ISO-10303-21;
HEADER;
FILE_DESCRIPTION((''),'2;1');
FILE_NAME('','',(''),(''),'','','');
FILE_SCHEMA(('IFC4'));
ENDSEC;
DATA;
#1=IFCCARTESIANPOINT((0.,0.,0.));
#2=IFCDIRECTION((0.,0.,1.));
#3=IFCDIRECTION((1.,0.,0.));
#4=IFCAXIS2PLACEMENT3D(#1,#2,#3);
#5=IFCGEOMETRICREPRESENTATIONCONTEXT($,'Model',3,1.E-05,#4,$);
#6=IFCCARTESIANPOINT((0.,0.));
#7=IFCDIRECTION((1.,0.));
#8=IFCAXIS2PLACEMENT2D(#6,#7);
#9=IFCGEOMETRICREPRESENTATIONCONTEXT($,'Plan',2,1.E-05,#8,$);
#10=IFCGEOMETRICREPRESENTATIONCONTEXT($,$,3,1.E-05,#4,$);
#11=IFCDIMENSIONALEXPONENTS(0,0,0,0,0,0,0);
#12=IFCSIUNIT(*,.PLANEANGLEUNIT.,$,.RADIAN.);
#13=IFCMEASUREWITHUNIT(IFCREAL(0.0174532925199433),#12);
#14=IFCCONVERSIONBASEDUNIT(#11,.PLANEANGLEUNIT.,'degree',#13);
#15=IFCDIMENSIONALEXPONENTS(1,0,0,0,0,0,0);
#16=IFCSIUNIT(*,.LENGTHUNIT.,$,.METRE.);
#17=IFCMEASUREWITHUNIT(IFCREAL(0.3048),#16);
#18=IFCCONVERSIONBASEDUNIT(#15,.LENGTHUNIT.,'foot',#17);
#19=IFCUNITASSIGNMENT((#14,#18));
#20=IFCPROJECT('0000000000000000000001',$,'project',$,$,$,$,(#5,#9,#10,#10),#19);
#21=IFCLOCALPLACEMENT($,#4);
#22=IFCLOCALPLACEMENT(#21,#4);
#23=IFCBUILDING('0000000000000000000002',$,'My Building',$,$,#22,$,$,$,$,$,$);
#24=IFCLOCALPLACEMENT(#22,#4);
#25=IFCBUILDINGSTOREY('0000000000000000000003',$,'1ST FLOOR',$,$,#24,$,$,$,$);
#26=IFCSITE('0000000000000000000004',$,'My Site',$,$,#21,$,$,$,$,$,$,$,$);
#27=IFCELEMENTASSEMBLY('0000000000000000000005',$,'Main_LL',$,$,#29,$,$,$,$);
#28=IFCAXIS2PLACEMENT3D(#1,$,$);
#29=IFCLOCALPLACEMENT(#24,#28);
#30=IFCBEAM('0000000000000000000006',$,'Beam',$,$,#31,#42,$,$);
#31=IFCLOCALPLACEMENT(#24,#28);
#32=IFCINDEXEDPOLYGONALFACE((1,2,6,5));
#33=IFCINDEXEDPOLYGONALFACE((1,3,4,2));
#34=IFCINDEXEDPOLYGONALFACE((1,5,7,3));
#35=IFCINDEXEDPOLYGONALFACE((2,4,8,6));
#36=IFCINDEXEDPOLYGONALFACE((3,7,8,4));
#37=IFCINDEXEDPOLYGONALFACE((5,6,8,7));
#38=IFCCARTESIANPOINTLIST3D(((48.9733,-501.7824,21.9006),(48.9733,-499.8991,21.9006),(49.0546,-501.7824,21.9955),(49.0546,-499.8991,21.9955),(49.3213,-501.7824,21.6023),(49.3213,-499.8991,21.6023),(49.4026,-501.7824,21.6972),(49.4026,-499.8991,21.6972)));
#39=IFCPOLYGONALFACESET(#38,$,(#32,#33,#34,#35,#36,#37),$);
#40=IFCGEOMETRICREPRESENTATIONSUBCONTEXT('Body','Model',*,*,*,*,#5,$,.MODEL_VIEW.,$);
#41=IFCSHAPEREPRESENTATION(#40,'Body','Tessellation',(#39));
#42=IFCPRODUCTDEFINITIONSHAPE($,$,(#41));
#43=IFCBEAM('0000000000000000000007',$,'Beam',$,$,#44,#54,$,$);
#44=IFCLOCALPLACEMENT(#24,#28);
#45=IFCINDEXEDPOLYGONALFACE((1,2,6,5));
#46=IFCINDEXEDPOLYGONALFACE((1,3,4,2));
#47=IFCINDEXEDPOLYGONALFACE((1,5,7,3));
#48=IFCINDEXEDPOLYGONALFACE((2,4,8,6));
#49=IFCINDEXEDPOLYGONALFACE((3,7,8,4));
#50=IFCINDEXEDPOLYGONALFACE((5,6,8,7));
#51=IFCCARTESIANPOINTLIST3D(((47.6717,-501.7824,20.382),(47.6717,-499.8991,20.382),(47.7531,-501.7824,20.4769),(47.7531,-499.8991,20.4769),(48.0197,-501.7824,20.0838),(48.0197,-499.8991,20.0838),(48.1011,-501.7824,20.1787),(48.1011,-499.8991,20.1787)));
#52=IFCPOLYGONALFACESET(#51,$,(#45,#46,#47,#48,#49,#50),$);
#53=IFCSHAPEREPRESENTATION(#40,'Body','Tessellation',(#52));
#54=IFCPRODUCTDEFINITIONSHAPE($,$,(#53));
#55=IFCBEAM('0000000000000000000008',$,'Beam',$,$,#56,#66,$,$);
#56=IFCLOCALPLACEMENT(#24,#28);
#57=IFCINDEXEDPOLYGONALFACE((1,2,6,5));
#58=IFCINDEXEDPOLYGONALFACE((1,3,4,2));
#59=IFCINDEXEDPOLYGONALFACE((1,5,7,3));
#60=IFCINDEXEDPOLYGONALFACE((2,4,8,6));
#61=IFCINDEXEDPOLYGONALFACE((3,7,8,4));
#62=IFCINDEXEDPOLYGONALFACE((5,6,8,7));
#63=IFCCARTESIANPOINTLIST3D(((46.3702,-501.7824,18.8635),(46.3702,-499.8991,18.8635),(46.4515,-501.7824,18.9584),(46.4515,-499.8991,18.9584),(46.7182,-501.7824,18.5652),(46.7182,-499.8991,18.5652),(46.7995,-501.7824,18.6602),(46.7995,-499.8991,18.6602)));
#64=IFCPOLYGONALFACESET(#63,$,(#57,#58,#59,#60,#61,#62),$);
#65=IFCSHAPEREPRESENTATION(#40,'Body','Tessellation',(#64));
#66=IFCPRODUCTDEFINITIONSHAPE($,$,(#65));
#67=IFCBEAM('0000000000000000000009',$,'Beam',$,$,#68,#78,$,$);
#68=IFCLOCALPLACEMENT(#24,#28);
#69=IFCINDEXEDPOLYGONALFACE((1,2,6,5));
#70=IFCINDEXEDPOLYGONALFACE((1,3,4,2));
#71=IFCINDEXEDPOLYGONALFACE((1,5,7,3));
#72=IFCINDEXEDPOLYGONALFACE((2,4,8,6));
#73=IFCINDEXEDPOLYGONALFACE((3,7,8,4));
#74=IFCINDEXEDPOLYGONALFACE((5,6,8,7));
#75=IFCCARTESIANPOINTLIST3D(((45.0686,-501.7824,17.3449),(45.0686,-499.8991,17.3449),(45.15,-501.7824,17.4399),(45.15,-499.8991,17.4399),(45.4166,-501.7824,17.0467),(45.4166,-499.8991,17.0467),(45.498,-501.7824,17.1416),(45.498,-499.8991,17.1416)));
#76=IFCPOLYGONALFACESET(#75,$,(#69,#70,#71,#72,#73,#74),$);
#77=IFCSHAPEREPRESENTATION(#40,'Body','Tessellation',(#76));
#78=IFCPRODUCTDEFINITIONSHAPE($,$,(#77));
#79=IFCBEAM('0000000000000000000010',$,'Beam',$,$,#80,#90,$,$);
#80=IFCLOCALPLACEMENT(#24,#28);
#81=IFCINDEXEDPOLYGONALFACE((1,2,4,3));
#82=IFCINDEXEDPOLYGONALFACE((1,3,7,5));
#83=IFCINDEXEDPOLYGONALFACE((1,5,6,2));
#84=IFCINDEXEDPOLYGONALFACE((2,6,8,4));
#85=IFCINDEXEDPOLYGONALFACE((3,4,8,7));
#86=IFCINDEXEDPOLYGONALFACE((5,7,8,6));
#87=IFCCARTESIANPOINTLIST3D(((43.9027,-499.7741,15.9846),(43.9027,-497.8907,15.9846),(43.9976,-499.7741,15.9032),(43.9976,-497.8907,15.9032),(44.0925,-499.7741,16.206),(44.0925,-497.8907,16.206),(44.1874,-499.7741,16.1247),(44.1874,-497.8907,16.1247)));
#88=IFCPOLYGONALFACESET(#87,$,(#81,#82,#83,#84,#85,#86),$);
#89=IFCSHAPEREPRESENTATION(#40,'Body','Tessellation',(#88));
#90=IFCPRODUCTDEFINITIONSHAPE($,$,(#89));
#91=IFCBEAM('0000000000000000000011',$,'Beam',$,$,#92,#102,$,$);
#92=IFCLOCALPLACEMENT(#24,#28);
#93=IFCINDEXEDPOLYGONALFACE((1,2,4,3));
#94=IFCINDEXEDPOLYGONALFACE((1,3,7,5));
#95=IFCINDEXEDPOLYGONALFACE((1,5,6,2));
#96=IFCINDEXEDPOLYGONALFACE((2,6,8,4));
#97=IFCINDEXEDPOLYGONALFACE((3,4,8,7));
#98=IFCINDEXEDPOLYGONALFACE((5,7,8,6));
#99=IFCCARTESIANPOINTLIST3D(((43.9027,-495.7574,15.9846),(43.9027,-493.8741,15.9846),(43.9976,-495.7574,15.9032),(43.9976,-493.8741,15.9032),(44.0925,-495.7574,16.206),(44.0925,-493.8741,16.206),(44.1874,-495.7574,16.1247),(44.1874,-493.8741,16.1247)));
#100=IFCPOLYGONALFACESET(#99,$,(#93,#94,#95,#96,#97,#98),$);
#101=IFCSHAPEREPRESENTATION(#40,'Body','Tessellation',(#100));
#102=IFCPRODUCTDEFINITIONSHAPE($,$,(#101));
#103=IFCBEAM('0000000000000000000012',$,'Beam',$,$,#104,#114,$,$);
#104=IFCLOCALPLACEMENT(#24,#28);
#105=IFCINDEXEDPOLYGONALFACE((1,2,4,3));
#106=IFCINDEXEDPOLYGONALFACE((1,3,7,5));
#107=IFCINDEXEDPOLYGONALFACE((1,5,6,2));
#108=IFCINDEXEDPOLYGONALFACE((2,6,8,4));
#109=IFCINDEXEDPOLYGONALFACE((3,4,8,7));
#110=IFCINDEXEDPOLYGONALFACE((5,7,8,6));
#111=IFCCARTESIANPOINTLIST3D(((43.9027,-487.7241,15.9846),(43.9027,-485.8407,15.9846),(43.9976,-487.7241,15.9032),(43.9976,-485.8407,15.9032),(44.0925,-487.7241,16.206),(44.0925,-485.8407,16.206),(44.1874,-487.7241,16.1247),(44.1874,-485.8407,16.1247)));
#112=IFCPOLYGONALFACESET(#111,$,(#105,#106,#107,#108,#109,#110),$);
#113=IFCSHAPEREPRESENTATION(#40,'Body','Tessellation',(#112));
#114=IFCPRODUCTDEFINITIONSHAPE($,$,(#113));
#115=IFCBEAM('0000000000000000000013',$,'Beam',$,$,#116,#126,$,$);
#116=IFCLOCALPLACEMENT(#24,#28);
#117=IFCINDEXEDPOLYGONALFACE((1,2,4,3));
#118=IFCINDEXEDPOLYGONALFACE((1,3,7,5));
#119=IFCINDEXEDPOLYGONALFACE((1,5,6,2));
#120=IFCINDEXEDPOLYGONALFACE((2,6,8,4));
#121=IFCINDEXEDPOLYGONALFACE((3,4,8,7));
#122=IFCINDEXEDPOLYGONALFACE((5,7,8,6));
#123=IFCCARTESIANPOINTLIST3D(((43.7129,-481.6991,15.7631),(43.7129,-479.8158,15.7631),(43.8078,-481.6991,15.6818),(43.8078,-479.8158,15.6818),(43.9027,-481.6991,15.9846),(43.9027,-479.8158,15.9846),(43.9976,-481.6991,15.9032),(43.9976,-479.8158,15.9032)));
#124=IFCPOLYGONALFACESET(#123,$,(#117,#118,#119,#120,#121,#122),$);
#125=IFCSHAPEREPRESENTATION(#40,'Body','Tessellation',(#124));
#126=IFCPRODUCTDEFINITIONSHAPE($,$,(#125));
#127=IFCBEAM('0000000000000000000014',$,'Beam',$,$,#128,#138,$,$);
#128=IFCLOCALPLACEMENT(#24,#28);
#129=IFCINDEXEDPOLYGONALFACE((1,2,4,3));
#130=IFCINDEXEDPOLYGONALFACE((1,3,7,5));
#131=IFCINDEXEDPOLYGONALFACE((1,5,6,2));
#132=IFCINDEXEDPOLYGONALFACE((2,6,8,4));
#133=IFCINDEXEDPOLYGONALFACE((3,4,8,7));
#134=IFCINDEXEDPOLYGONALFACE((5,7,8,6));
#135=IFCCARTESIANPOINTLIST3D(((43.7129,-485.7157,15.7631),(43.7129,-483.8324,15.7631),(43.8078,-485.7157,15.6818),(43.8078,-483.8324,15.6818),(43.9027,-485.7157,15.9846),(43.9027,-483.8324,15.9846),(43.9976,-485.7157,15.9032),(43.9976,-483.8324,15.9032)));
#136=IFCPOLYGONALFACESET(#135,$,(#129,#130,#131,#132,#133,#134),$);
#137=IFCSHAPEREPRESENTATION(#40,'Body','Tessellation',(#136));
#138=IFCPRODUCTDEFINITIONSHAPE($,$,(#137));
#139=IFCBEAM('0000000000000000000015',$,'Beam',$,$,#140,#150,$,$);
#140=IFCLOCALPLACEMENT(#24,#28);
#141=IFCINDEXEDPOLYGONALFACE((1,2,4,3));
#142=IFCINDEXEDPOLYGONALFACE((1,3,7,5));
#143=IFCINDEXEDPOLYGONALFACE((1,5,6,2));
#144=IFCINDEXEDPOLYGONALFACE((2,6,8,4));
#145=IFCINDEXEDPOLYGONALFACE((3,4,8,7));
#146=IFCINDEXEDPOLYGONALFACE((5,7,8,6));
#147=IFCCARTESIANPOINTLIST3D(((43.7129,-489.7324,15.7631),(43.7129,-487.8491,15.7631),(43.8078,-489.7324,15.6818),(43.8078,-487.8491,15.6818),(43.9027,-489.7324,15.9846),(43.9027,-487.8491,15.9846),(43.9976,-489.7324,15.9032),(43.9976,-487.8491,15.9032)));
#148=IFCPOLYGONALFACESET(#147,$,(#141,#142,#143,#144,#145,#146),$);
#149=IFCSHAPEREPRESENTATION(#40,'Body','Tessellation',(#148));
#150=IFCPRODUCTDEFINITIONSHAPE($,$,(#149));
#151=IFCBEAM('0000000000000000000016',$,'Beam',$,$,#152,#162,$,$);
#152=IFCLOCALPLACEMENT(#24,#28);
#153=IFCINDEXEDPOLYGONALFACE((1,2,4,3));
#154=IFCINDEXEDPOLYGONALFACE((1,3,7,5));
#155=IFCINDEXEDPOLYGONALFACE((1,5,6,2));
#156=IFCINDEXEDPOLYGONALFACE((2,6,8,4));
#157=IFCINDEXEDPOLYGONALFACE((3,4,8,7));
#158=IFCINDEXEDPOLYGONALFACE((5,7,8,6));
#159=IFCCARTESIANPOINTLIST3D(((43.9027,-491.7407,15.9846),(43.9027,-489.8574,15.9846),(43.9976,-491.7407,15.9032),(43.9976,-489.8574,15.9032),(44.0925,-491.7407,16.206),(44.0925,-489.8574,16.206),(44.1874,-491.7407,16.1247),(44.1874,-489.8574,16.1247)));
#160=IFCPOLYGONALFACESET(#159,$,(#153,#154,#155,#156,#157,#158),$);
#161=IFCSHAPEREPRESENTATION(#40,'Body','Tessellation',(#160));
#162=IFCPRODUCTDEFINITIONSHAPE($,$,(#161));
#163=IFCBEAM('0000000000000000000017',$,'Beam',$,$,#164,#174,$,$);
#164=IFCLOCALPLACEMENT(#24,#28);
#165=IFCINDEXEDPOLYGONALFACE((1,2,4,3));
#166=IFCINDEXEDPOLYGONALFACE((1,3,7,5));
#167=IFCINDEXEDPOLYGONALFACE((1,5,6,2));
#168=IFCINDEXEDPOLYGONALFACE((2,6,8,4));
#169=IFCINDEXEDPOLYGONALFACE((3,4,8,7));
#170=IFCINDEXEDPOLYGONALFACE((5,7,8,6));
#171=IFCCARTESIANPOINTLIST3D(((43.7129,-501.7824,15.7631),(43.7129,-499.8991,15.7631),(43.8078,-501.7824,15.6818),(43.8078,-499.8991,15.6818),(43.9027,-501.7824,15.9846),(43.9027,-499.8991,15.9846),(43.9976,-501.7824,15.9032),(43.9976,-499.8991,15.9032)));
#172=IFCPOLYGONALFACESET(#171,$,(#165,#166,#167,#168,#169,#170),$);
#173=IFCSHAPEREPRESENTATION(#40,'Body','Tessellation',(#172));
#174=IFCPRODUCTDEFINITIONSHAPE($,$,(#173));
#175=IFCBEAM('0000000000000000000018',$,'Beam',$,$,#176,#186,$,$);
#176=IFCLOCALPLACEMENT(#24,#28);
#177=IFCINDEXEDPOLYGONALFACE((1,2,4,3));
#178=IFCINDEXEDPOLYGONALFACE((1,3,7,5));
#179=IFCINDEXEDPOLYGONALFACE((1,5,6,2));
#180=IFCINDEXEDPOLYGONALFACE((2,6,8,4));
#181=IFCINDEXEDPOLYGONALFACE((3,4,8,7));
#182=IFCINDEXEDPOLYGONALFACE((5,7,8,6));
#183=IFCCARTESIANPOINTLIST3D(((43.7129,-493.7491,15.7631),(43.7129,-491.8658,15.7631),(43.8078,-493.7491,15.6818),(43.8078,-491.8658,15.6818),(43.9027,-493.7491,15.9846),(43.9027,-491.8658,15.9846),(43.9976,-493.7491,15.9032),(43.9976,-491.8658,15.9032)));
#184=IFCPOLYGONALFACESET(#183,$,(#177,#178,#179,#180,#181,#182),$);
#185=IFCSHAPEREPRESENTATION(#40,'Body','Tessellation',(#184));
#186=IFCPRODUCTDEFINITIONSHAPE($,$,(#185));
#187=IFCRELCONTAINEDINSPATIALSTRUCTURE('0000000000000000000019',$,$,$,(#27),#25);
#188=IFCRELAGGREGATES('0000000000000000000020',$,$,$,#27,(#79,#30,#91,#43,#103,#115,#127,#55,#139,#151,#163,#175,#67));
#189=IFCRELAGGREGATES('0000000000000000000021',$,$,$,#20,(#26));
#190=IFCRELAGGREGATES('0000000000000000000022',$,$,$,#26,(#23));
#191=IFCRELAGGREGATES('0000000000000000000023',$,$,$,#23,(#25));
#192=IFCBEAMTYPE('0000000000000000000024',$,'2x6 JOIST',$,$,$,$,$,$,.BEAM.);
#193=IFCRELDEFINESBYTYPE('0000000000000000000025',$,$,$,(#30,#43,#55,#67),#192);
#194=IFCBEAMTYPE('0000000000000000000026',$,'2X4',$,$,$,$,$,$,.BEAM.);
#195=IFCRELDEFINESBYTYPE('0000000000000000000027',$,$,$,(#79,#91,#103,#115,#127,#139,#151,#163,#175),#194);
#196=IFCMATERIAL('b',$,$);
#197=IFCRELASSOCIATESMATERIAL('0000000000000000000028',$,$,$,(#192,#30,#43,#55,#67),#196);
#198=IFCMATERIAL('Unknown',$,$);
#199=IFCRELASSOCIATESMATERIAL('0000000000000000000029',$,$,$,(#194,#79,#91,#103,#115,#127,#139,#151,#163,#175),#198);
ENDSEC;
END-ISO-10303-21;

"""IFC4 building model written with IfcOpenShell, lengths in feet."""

from ifc_helpers import new_model, entity, si_unit, converted_unit, frame, origin_with_axes, origin_2d_with_axis, place, context, subcontext, project, spatial, rectangle, extrude, material, material_profile, profile_set, profile_usage, type_object, element, aggregate, save


model = new_model("IFC4")

# Units and contexts
model_context = context("Model", 3, precision=1e-05, world=origin_with_axes())
plan_context = context("Plan", 2, precision=1e-05, world=origin_2d_with_axis())
context_of_model = context(None, 3, precision=1e-05, world=origin_with_axes())
body_context = subcontext(model_context, "Body", "Model", "MODEL_VIEW")
ifc_project = project(units=[converted_unit("PLANEANGLEUNIT", "degree", entity("IfcReal", 0.0174532925199433), si_unit("PLANEANGLEUNIT", "RADIAN"), dimensions=[0, 0, 0, 0, 0, 0, 0]), converted_unit("LENGTHUNIT", "foot", entity("IfcReal", 0.3048), si_unit("LENGTHUNIT", "METRE"), dimensions=[1, 0, 0, 0, 0, 0, 0])], contexts=[model_context, plan_context, context_of_model, context_of_model])

# Site, building, storey
site_placement = place(None, origin_with_axes())
site = spatial("IfcSite", under=ifc_project, at=site_placement, Name="My Site")
building_placement = place(site_placement, origin_with_axes())
building = spatial("IfcBuilding", under=site, at=building_placement, Name="My Building")
storey_placement = place(building_placement, origin_with_axes())
storey = spatial("IfcBuildingStorey", under=building, at=storey_placement, Name="1ST FLOOR")

# Element assembly, beams
assembly_placement = place(storey_placement, origin_with_axes())
assembly = element("IfcElementAssembly", 1, at=assembly_placement, inside=storey, Name="Main_LL")
ifc_material_1 = material(Name="b")
ifc_material_profile_1 = material_profile(ifc_material_1, rectangle(XDim=0.125, YDim=0.4583))
ifc_profile_set_1 = profile_set([ifc_material_profile_1])
ifc_profile_usage_1 = profile_usage(ifc_profile_set_1, cardinal=8)
beam_type_1 = type_object("IfcBeamType", Name="2x6 JOIST", PredefinedType="BEAM", material=ifc_profile_set_1)
beam_1_placement = place(assembly_placement, frame((49.014, -499.8991, 21.948), z_axis=(0.0, -1.0, 0.0), x_axis=(0.650774, 0.0, 0.759271)))
beam_1 = element("IfcBeam", 2, at=beam_1_placement, type_object=beam_type_1, material=ifc_profile_usage_1, Name="Beam", context=body_context, shape_type="SweptSolid", body=[
    extrude(rectangle(XDim=0.125, YDim=0.4583), frame((0.0, -0.2291, 0.0)), (0.0, 0.0, 1.0), 1.8833),
])
ifc_profile_usage_2 = profile_usage(ifc_profile_set_1, cardinal=8)
beam_2_placement = place(assembly_placement, frame((47.7124, -499.8991, 20.4295), z_axis=(0.0, -1.0, 0.0), x_axis=(0.650774, 0.0, 0.759271)))
beam_2 = element("IfcBeam", 3, at=beam_2_placement, type_object=beam_type_1, material=ifc_profile_usage_2, Name="Beam", context=body_context, shape_type="SweptSolid", body=[
    extrude(rectangle(XDim=0.125, YDim=0.4583), frame((0.0, -0.2291, 0.0)), (0.0, 0.0, 1.0), 1.8833),
])
ifc_profile_usage_3 = profile_usage(ifc_profile_set_1, cardinal=8)
beam_3_placement = place(assembly_placement, frame((46.4109, -499.8991, 18.9109), z_axis=(0.0, -1.0, 0.0), x_axis=(0.650774, 0.0, 0.759271)))
beam_3 = element("IfcBeam", 4, at=beam_3_placement, type_object=beam_type_1, material=ifc_profile_usage_3, Name="Beam", context=body_context, shape_type="SweptSolid", body=[
    extrude(rectangle(XDim=0.125, YDim=0.4583), frame((0.0, -0.2291, 0.0)), (0.0, 0.0, 1.0), 1.8833),
])
ifc_profile_usage_4 = profile_usage(ifc_profile_set_1, cardinal=8)
beam_4_placement = place(assembly_placement, frame((45.1093, -499.8991, 17.3924), z_axis=(0.0, -1.0, 0.0), x_axis=(0.650774, 0.0, 0.759271)))
beam_4 = element("IfcBeam", 5, at=beam_4_placement, type_object=beam_type_1, material=ifc_profile_usage_4, Name="Beam", context=body_context, shape_type="SweptSolid", body=[
    extrude(rectangle(XDim=0.125, YDim=0.4583), frame((0.0, -0.2291, 0.0)), (0.0, 0.0, 1.0), 1.8833),
])
ifc_material_2 = material(Name="Unknown")
ifc_material_profile_2 = material_profile(ifc_material_2, rectangle(XDim=0.125, YDim=0.2917))
ifc_profile_set_2 = profile_set([ifc_material_profile_2])
ifc_profile_usage_5 = profile_usage(ifc_profile_set_2, cardinal=5)
beam_type_2 = type_object("IfcBeamType", Name="2X4", PredefinedType="BEAM", material=ifc_profile_set_2)
beam_5_placement = place(assembly_placement, frame((44.045, -497.8907, 16.0546), z_axis=(0.0, -1.0, 0.0), x_axis=(-0.759271, 0.0, 0.650774)))
beam_5 = element("IfcBeam", 6, at=beam_5_placement, type_object=beam_type_2, material=ifc_profile_usage_5, Name="Beam", context=body_context, shape_type="SweptSolid", body=[
    extrude(rectangle(XDim=0.125, YDim=0.2917), origin_with_axes(), (0.0, 0.0, 1.0), 1.8833),
])
ifc_profile_usage_6 = profile_usage(ifc_profile_set_2, cardinal=5)
beam_6_placement = place(assembly_placement, frame((44.045, -493.8741, 16.0546), z_axis=(0.0, -1.0, 0.0), x_axis=(-0.759271, 0.0, 0.650774)))
beam_6 = element("IfcBeam", 7, at=beam_6_placement, type_object=beam_type_2, material=ifc_profile_usage_6, Name="Beam", context=body_context, shape_type="SweptSolid", body=[
    extrude(rectangle(XDim=0.125, YDim=0.2917), origin_with_axes(), (0.0, 0.0, 1.0), 1.8833),
])
ifc_profile_usage_7 = profile_usage(ifc_profile_set_2, cardinal=5)
beam_7_placement = place(assembly_placement, frame((44.045, -485.8407, 16.0546), z_axis=(0.0, -1.0, 0.0), x_axis=(-0.759271, 0.0, 0.650774)))
beam_7 = element("IfcBeam", 8, at=beam_7_placement, type_object=beam_type_2, material=ifc_profile_usage_7, Name="Beam", context=body_context, shape_type="SweptSolid", body=[
    extrude(rectangle(XDim=0.125, YDim=0.2917), origin_with_axes(), (0.0, 0.0, 1.0), 1.8833),
])
ifc_profile_usage_8 = profile_usage(ifc_profile_set_2, cardinal=5)
beam_8_placement = place(assembly_placement, frame((43.8552, -479.8158, 15.8332), z_axis=(0.0, -1.0, 0.0), x_axis=(-0.759271, 0.0, 0.650774)))
beam_8 = element("IfcBeam", 9, at=beam_8_placement, type_object=beam_type_2, material=ifc_profile_usage_8, Name="Beam", context=body_context, shape_type="SweptSolid", body=[
    extrude(rectangle(XDim=0.125, YDim=0.2917), origin_with_axes(), (0.0, 0.0, 1.0), 1.8833),
])
ifc_profile_usage_9 = profile_usage(ifc_profile_set_2, cardinal=5)
beam_9_placement = place(assembly_placement, frame((43.8552, -483.8324, 15.8332), z_axis=(0.0, -1.0, 0.0), x_axis=(-0.759271, 0.0, 0.650774)))
beam_9 = element("IfcBeam", 10, at=beam_9_placement, type_object=beam_type_2, material=ifc_profile_usage_9, Name="Beam", context=body_context, shape_type="SweptSolid", body=[
    extrude(rectangle(XDim=0.125, YDim=0.2917), origin_with_axes(), (0.0, 0.0, 1.0), 1.8833),
])
ifc_profile_usage_10 = profile_usage(ifc_profile_set_2, cardinal=5)
beam_10_placement = place(assembly_placement, frame((43.8552, -487.8491, 15.8332), z_axis=(0.0, -1.0, 0.0), x_axis=(-0.759271, 0.0, 0.650774)))
beam_10 = element("IfcBeam", 11, at=beam_10_placement, type_object=beam_type_2, material=ifc_profile_usage_10, Name="Beam", context=body_context, shape_type="SweptSolid", body=[
    extrude(rectangle(XDim=0.125, YDim=0.2917), origin_with_axes(), (0.0, 0.0, 1.0), 1.8833),
])
ifc_profile_usage_11 = profile_usage(ifc_profile_set_2, cardinal=5)
beam_11_placement = place(assembly_placement, frame((44.045, -489.8574, 16.0546), z_axis=(0.0, -1.0, 0.0), x_axis=(-0.759271, 0.0, 0.650774)))
beam_11 = element("IfcBeam", 12, at=beam_11_placement, type_object=beam_type_2, material=ifc_profile_usage_11, Name="Beam", context=body_context, shape_type="SweptSolid", body=[
    extrude(rectangle(XDim=0.125, YDim=0.2917), origin_with_axes(), (0.0, 0.0, 1.0), 1.8833),
])
ifc_profile_usage_12 = profile_usage(ifc_profile_set_2, cardinal=5)
beam_12_placement = place(assembly_placement, frame((43.8552, -499.8991, 15.8332), z_axis=(0.0, -1.0, 0.0), x_axis=(-0.759271, 0.0, 0.650774)))
beam_12 = element("IfcBeam", 13, at=beam_12_placement, type_object=beam_type_2, material=ifc_profile_usage_12, Name="Beam", context=body_context, shape_type="SweptSolid", body=[
    extrude(rectangle(XDim=0.125, YDim=0.2917), origin_with_axes(), (0.0, 0.0, 1.0), 1.8833),
])
ifc_profile_usage_13 = profile_usage(ifc_profile_set_2, cardinal=5)
beam_13_placement = place(assembly_placement, frame((43.8552, -491.8658, 15.8332), z_axis=(0.0, -1.0, 0.0), x_axis=(-0.759271, 0.0, 0.650774)))
beam_13 = element("IfcBeam", 14, at=beam_13_placement, type_object=beam_type_2, material=ifc_profile_usage_13, Name="Beam", context=body_context, shape_type="SweptSolid", body=[
    extrude(rectangle(XDim=0.125, YDim=0.2917), origin_with_axes(), (0.0, 0.0, 1.0), 1.8833),
])
aggregate(assembly, [beam_5, beam_1, beam_6, beam_2, beam_7, beam_8, beam_9, beam_3, beam_10, beam_11, beam_12, beam_13, beam_4])

save(model, "model.ifc")
